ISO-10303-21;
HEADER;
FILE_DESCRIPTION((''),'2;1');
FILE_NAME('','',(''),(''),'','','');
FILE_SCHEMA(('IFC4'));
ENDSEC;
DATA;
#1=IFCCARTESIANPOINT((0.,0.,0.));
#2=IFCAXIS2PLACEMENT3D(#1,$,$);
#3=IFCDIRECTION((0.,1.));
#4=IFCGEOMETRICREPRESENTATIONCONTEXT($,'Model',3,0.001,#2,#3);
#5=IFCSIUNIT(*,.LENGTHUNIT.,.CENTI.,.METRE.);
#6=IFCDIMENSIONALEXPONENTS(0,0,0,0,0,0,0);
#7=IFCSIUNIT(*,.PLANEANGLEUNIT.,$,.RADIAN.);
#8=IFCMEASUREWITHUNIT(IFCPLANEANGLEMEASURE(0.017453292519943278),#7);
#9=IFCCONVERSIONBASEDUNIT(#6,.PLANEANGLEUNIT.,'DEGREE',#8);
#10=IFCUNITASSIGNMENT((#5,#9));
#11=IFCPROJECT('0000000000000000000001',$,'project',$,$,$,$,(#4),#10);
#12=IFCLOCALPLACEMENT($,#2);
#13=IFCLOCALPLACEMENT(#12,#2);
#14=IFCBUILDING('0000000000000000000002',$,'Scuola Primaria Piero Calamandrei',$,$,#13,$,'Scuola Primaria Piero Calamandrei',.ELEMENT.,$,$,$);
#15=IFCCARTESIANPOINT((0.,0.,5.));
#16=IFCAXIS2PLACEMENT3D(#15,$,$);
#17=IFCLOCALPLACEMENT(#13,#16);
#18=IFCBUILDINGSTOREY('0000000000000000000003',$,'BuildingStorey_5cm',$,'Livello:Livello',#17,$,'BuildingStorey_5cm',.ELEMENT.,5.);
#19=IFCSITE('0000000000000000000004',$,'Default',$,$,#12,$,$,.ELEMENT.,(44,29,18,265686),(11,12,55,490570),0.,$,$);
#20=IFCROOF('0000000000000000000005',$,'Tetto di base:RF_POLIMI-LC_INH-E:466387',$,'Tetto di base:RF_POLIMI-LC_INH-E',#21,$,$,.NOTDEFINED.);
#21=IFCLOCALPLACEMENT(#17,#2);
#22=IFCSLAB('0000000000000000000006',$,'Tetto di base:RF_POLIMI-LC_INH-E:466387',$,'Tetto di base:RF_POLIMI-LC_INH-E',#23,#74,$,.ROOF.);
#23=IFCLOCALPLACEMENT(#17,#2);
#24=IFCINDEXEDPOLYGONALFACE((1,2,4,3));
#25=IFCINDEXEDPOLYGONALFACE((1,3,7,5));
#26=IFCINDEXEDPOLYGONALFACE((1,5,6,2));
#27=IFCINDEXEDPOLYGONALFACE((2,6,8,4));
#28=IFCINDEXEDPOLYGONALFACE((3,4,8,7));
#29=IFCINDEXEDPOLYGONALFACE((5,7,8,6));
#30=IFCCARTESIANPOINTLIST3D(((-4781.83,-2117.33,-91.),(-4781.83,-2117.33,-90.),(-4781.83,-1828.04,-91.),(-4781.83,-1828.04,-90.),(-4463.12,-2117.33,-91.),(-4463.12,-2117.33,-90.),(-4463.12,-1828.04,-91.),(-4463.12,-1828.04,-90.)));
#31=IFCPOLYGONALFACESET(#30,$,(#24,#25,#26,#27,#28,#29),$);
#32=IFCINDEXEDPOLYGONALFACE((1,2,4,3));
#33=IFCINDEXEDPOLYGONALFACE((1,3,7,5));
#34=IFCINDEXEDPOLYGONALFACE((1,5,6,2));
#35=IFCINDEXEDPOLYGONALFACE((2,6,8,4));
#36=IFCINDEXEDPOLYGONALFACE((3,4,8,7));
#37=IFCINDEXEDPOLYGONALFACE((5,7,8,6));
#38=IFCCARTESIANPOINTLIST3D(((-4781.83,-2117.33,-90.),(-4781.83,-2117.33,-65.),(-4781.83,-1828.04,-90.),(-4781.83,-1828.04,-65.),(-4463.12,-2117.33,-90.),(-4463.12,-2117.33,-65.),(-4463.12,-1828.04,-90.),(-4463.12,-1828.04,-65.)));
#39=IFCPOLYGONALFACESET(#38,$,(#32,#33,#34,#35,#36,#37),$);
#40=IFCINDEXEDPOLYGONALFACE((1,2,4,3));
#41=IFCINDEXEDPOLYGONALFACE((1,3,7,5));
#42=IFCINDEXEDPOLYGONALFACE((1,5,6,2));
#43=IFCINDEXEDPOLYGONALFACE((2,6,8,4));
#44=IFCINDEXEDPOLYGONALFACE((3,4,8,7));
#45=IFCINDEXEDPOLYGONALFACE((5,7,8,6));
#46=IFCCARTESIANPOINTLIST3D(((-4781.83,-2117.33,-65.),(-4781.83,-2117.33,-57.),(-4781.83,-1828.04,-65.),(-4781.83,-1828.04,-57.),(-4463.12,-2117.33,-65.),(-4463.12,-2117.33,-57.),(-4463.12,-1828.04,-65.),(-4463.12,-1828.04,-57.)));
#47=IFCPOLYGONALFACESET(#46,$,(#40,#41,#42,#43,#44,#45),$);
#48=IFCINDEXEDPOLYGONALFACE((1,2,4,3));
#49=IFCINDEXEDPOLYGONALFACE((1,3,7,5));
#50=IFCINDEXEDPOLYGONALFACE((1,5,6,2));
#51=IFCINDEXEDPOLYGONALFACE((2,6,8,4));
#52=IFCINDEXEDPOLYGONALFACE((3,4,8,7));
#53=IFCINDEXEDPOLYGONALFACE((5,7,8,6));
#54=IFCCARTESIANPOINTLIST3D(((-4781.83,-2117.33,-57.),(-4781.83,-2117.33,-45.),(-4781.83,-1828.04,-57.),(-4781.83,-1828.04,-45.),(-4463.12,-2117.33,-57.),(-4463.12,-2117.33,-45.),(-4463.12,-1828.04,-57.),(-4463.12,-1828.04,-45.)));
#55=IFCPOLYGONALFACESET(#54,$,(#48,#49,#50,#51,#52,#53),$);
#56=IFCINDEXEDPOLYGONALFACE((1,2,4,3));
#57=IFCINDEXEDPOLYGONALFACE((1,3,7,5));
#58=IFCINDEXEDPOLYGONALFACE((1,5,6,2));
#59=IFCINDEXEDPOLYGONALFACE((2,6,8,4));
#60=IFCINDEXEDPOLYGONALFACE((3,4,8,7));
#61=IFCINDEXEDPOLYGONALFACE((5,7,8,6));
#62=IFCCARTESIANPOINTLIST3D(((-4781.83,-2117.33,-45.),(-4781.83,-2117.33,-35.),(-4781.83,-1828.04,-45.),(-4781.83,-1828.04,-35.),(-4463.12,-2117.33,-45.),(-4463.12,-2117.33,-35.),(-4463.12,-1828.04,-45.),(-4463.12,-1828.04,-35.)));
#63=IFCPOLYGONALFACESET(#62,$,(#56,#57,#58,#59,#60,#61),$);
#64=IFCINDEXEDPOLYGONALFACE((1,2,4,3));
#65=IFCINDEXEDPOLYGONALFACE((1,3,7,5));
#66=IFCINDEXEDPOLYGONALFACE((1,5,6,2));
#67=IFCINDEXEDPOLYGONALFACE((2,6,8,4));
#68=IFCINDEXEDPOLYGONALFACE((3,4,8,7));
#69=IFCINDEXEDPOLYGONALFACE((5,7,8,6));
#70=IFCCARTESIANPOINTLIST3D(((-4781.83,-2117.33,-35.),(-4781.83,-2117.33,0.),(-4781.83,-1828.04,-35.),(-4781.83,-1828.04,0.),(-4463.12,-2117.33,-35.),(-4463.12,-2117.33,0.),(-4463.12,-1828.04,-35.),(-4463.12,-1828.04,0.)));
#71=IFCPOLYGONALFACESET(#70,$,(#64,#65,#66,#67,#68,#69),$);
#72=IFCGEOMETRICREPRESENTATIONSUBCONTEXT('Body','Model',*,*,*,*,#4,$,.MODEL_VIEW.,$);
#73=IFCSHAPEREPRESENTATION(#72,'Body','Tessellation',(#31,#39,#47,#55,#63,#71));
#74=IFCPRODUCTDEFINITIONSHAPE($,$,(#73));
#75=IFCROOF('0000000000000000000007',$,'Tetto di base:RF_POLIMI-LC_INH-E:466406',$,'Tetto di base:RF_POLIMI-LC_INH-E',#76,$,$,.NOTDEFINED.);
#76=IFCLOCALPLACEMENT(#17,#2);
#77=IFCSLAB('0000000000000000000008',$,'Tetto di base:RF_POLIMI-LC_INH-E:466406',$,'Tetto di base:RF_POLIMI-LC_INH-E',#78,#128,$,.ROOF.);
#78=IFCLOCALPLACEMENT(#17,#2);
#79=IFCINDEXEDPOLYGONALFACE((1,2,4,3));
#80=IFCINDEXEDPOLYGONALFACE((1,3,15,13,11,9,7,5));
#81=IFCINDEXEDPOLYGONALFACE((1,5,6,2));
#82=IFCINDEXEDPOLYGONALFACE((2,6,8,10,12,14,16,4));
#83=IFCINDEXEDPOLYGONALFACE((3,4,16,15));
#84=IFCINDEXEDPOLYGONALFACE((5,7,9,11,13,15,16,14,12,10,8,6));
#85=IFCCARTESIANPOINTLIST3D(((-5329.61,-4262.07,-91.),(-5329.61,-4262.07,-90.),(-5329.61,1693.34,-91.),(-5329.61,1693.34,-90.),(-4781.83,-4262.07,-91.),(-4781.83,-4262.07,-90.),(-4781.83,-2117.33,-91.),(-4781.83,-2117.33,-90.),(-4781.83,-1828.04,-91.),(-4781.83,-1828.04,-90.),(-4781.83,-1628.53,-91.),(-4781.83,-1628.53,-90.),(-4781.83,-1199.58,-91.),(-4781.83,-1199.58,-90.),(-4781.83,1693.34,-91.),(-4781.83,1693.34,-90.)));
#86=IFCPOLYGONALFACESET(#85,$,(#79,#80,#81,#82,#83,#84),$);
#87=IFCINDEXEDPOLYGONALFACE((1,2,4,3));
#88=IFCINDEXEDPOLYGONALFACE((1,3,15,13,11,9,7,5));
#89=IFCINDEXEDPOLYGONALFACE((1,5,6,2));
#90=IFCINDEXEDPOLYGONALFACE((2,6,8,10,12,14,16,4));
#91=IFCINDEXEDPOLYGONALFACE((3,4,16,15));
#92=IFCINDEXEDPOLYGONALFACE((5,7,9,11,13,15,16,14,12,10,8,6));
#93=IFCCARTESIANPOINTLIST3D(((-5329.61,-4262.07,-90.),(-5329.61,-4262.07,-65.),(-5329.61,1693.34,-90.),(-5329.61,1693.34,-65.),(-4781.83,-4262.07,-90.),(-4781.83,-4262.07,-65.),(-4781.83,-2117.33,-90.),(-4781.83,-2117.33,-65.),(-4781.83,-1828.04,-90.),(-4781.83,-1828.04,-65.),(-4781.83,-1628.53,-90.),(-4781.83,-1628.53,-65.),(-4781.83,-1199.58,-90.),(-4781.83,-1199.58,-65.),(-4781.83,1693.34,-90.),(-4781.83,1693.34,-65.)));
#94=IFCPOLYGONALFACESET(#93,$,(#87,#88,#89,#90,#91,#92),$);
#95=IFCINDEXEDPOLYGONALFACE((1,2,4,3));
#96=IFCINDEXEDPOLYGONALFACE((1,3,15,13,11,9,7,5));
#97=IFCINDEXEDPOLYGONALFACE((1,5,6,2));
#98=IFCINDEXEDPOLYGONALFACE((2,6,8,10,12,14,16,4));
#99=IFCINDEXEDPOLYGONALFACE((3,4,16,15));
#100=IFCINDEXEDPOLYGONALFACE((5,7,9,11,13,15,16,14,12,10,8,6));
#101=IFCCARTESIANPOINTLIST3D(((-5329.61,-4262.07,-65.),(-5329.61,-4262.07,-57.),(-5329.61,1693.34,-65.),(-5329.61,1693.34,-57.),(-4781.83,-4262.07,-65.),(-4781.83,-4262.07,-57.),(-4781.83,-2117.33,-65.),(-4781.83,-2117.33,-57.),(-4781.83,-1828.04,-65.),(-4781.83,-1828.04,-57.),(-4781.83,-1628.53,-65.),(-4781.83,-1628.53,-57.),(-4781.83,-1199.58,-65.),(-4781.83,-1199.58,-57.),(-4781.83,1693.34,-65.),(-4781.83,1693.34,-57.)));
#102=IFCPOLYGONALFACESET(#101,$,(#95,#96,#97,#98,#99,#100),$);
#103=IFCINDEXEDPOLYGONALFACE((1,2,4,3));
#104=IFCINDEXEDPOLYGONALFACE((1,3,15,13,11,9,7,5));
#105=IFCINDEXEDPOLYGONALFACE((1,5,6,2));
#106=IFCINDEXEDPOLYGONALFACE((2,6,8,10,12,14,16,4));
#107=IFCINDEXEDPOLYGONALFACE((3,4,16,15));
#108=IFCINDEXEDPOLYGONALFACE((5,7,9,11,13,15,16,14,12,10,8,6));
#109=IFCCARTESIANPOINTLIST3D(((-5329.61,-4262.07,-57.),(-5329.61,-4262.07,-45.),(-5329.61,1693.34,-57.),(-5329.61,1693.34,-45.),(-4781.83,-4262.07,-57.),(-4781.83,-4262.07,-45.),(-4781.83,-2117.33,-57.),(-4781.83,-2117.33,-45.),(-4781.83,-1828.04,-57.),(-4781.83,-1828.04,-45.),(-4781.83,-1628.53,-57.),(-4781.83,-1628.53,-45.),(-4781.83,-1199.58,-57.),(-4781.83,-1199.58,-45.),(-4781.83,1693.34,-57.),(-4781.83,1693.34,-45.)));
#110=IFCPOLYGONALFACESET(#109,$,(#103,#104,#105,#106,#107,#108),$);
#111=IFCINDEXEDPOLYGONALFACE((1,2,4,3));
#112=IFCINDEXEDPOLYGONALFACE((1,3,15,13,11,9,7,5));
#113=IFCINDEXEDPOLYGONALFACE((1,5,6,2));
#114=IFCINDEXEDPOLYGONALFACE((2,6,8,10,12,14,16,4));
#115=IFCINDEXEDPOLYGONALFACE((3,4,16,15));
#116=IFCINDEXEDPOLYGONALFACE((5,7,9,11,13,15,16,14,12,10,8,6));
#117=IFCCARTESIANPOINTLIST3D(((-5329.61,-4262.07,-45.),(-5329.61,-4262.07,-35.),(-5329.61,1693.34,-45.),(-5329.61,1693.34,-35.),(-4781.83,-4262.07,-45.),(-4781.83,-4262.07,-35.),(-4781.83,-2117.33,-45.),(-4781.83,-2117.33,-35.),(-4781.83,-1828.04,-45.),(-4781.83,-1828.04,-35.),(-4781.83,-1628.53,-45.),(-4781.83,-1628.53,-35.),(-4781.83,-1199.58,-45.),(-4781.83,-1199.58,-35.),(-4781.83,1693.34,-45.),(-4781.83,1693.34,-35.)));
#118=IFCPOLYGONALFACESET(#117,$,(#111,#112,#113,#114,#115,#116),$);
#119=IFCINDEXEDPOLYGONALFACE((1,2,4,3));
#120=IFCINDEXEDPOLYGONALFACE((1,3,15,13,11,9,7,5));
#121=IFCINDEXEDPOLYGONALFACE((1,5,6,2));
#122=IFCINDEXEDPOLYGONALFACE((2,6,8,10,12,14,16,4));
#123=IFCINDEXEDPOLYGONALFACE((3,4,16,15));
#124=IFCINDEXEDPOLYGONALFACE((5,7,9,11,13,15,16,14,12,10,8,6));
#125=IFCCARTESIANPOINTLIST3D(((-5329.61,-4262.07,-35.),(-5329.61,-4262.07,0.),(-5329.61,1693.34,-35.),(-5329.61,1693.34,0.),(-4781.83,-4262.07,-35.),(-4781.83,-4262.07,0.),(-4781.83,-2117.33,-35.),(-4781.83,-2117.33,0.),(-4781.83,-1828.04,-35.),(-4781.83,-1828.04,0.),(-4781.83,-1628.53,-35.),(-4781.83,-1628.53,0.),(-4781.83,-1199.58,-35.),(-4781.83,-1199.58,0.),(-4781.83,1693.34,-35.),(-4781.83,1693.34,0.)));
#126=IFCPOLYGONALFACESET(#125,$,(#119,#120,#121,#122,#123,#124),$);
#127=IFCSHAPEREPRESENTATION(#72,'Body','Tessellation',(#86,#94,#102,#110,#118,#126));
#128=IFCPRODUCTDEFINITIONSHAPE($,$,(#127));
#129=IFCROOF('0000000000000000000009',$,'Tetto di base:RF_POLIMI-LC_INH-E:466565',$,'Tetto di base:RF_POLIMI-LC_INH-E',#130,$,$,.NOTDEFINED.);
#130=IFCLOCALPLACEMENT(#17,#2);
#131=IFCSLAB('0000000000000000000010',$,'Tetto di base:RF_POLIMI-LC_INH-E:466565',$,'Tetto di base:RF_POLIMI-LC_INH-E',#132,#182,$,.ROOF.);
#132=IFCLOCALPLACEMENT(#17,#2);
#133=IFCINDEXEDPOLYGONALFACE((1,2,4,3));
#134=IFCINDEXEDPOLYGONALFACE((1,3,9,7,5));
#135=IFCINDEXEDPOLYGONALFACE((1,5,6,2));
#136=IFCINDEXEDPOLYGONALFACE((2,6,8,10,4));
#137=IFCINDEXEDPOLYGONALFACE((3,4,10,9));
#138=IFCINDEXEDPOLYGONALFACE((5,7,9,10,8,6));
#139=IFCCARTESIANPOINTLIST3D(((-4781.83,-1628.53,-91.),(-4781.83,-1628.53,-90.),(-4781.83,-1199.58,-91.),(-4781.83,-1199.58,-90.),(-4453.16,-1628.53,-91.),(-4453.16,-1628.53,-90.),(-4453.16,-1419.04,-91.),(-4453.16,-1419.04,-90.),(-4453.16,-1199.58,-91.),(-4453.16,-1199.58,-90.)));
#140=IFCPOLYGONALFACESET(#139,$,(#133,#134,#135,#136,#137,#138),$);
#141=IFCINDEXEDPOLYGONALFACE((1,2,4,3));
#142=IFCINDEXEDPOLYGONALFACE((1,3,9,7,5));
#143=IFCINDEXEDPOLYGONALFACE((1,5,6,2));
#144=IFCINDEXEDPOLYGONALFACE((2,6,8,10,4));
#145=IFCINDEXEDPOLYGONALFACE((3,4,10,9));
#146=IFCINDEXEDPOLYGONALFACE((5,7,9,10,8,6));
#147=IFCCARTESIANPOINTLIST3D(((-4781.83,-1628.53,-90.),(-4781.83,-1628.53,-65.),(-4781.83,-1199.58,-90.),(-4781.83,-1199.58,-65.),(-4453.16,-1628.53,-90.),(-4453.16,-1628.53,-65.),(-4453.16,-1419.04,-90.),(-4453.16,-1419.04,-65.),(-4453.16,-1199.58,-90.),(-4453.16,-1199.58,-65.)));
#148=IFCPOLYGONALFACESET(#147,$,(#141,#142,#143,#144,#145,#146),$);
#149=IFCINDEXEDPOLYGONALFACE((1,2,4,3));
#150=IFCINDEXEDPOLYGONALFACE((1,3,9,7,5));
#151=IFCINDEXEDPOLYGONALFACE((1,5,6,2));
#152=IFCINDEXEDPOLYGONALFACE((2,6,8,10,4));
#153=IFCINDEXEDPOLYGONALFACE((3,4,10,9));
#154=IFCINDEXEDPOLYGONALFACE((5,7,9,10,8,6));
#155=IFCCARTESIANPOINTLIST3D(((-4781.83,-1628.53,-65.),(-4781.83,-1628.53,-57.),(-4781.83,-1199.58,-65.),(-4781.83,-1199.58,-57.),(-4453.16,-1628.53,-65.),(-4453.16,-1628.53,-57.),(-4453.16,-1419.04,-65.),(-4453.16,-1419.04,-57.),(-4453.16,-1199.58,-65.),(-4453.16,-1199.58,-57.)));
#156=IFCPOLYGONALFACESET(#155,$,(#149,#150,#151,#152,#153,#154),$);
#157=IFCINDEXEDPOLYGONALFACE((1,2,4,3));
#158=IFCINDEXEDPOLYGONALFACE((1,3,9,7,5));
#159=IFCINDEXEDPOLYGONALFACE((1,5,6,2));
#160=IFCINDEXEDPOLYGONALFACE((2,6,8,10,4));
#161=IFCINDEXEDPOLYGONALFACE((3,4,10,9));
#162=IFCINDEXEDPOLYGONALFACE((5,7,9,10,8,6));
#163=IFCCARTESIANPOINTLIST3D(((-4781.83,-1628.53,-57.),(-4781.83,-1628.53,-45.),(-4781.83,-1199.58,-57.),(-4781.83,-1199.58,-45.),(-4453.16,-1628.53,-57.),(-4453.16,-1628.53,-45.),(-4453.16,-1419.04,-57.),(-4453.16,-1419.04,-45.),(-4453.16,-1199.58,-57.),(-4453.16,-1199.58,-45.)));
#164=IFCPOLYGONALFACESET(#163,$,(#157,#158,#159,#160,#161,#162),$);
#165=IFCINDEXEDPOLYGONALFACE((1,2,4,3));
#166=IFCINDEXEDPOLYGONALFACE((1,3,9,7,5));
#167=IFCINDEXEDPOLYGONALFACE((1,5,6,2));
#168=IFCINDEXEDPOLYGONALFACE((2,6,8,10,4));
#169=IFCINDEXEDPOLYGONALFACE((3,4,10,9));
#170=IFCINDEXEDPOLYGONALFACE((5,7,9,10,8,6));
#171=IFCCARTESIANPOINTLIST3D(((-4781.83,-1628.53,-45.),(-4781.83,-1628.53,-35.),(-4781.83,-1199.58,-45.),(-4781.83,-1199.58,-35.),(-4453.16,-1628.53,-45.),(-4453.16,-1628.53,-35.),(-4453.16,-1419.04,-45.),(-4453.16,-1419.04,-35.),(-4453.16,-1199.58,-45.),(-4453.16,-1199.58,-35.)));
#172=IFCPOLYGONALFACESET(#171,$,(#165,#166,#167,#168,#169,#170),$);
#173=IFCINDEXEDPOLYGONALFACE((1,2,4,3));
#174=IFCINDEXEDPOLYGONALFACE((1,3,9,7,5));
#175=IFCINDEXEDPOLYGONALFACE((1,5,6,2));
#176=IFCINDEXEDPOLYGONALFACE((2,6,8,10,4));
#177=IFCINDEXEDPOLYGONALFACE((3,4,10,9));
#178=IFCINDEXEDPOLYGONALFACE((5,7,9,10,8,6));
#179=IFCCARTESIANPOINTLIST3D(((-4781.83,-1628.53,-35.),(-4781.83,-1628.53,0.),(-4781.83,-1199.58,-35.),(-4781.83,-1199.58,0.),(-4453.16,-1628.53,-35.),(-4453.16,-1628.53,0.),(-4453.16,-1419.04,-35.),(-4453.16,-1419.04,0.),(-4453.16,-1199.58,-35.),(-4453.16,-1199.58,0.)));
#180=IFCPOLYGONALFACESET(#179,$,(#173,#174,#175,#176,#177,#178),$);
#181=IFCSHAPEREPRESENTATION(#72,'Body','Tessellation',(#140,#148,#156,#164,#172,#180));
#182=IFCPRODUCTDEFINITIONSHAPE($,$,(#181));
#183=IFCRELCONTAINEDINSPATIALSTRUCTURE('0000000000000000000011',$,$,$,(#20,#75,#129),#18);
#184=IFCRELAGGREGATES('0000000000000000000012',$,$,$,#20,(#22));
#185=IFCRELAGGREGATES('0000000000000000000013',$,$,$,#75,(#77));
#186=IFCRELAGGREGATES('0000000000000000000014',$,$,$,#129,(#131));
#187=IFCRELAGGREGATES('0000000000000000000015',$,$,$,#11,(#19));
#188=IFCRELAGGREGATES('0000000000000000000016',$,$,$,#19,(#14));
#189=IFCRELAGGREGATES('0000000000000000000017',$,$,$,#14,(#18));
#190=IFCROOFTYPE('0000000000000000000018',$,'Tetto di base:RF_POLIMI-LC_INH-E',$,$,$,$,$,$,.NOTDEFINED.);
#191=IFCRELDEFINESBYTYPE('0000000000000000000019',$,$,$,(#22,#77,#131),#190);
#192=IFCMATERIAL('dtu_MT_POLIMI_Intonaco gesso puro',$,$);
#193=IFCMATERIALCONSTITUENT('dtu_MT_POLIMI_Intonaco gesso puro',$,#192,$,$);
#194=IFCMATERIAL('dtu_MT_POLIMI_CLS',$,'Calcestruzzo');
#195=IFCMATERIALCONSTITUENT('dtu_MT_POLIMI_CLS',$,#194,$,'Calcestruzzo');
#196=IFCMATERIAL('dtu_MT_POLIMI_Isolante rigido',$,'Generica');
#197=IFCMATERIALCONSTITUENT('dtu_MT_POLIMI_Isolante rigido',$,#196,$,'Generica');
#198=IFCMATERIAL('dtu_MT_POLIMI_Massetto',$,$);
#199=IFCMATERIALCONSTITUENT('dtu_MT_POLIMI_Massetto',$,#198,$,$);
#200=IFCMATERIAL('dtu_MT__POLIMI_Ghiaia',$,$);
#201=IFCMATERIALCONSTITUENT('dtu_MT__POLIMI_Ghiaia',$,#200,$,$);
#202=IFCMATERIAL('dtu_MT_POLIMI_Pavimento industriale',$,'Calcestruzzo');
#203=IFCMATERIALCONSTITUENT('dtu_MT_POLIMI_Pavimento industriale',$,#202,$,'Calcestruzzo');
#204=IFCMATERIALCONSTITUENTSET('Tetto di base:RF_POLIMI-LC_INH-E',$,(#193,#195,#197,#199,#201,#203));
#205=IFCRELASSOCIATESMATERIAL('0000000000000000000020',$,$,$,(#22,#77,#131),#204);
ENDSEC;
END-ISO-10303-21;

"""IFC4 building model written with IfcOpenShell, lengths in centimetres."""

from ifc_helpers import new_model, entity, si_unit, converted_unit, direction, frame, origin, place, context, subcontext, project, spatial, indexed_curve, outline, extrude, material, constituent, constituent_set, type_object, element, aggregate, save


model = new_model("IFC4")

# Units and contexts
model_context = context("Model", 3, precision=0.001, world=origin(), true_north=direction((0.0, 1.0)))
body_context = subcontext(model_context, "Body", "Model", "MODEL_VIEW")
ifc_project = project(units=[si_unit("LENGTHUNIT", "METRE", prefix="CENTI"), converted_unit("PLANEANGLEUNIT", "DEGREE", entity("IfcPlaneAngleMeasure", 0.017453292519943278), si_unit("PLANEANGLEUNIT", "RADIAN"), dimensions=[0, 0, 0, 0, 0, 0, 0])], contexts=[model_context])

# Site, building, storey
site_placement = place(None, origin())
site = spatial("IfcSite", under=ifc_project, at=site_placement, Name="Default", CompositionType="ELEMENT", RefLatitude=(44, 29, 18, 265686), RefLongitude=(11, 12, 55, 490570), RefElevation=0.0)
building_placement = place(site_placement, origin())
building = spatial("IfcBuilding", under=site, at=building_placement, Name="Scuola Primaria Piero Calamandrei", LongName="Scuola Primaria Piero Calamandrei", CompositionType="ELEMENT")
storey_placement = place(building_placement, frame((0.0, 0.0, 5.0)))
storey = spatial("IfcBuildingStorey", under=building, at=storey_placement, Name="BuildingStorey_5cm", ObjectType="Livello:Livello", LongName="BuildingStorey_5cm", CompositionType="ELEMENT", Elevation=5.0)

# Roofs, slabs
ifc_material_1 = material(Name="dtu_MT_POLIMI_Intonaco gesso puro")
ifc_constituent_1 = constituent(ifc_material_1, Name="dtu_MT_POLIMI_Intonaco gesso puro")
ifc_material_2 = material(Name="dtu_MT_POLIMI_CLS", Category="Calcestruzzo")
ifc_constituent_2 = constituent(ifc_material_2, Name="dtu_MT_POLIMI_CLS", Category="Calcestruzzo")
ifc_material_3 = material(Name="dtu_MT_POLIMI_Isolante rigido", Category="Generica")
ifc_constituent_3 = constituent(ifc_material_3, Name="dtu_MT_POLIMI_Isolante rigido", Category="Generica")
ifc_material_4 = material(Name="dtu_MT_POLIMI_Massetto")
ifc_constituent_4 = constituent(ifc_material_4, Name="dtu_MT_POLIMI_Massetto")
ifc_material_5 = material(Name="dtu_MT__POLIMI_Ghiaia")
ifc_constituent_5 = constituent(ifc_material_5, Name="dtu_MT__POLIMI_Ghiaia")
ifc_material_6 = material(Name="dtu_MT_POLIMI_Pavimento industriale", Category="Calcestruzzo")
ifc_constituent_6 = constituent(ifc_material_6, Name="dtu_MT_POLIMI_Pavimento industriale", Category="Calcestruzzo")
ifc_constituent_set_1 = constituent_set(constituents=[ifc_constituent_1, ifc_constituent_2, ifc_constituent_3, ifc_constituent_4, ifc_constituent_5, ifc_constituent_6], Name="Tetto di base:RF_POLIMI-LC_INH-E")
roof_type = type_object("IfcRoofType", Name="Tetto di base:RF_POLIMI-LC_INH-E", PredefinedType="NOTDEFINED")
roof_1_placement = place(storey_placement, frame((-4781.83, -2117.33, -91.0)))
roof_1 = element("IfcRoof", 1, at=roof_1_placement, inside=storey, Name="Tetto di base:RF_POLIMI-LC_INH-E:466387", ObjectType="Tetto di base:RF_POLIMI-LC_INH-E", PredefinedType="NOTDEFINED")
slab_1_placement = place(roof_1_placement, origin())
slab_1 = element("IfcSlab", 2, at=slab_1_placement, type_object=roof_type, material=ifc_constituent_set_1, Name="Tetto di base:RF_POLIMI-LC_INH-E:466387", ObjectType="Tetto di base:RF_POLIMI-LC_INH-E", PredefinedType="ROOF", context=body_context, shape_type="SweptSolid", body=[
    extrude(outline(indexed_curve([(159.35, 144.65), (-159.35, 144.65), (-159.35, -144.65), (159.35, -144.65), (159.35, 144.65)], self_intersect=False)), frame((159.35, 144.65, 0.0)), (0.0, 0.0, 1.0), 1.0),
    extrude(outline(indexed_curve([(159.35, 144.65), (-159.35, 144.65), (-159.35, -144.65), (159.35, -144.65), (159.35, 144.65)], self_intersect=False)), frame((159.35, 144.65, 1.0)), (0.0, 0.0, 1.0), 25.0),
    extrude(outline(indexed_curve([(159.35, 144.65), (-159.35, 144.65), (-159.35, -144.65), (159.35, -144.65), (159.35, 144.65)], self_intersect=False)), frame((159.35, 144.65, 26.0)), (0.0, 0.0, 1.0), 8.0),
    extrude(outline(indexed_curve([(159.35, 144.65), (-159.35, 144.65), (-159.35, -144.65), (159.35, -144.65), (159.35, 144.65)], self_intersect=False)), frame((159.35, 144.65, 34.0)), (0.0, 0.0, 1.0), 12.0),
    extrude(outline(indexed_curve([(159.35, 144.65), (-159.35, 144.65), (-159.35, -144.65), (159.35, -144.65), (159.35, 144.65)], self_intersect=False)), frame((159.35, 144.65, 46.0)), (0.0, 0.0, 1.0), 10.0),
    extrude(outline(indexed_curve([(159.35, 144.65), (-159.35, 144.65), (-159.35, -144.65), (159.35, -144.65), (159.35, 144.65)], self_intersect=False)), frame((159.35, 144.65, 56.0)), (0.0, 0.0, 1.0), 35.0),
])
aggregate(roof_1, [slab_1])
roof_2_placement = place(storey_placement, frame((-5329.61, -4262.07, -91.0)))
roof_2 = element("IfcRoof", 3, at=roof_2_placement, inside=storey, Name="Tetto di base:RF_POLIMI-LC_INH-E:466406", ObjectType="Tetto di base:RF_POLIMI-LC_INH-E", PredefinedType="NOTDEFINED")
slab_2_placement = place(roof_2_placement, origin())
slab_2 = element("IfcSlab", 4, at=slab_2_placement, type_object=roof_type, material=ifc_constituent_set_1, Name="Tetto di base:RF_POLIMI-LC_INH-E:466406", ObjectType="Tetto di base:RF_POLIMI-LC_INH-E", PredefinedType="ROOF", context=body_context, shape_type="SweptSolid", body=[
    extrude(outline(indexed_curve([(273.89, -543.67), (273.89, -344.16), (273.89, 84.79), (273.89, 2977.7), (-273.89, 2977.7), (-273.89, -2977.7), (273.89, -2977.7), (273.89, -832.96), (273.89, -543.67)], self_intersect=False)), frame((273.89, 2977.7, 0.0)), (0.0, 0.0, 1.0), 1.0),
    extrude(outline(indexed_curve([(273.89, -543.67), (273.89, -344.16), (273.89, 84.79), (273.89, 2977.7), (-273.89, 2977.7), (-273.89, -2977.7), (273.89, -2977.7), (273.89, -832.96), (273.89, -543.67)], self_intersect=False)), frame((273.89, 2977.7, 1.0)), (0.0, 0.0, 1.0), 25.0),
    extrude(outline(indexed_curve([(273.89, -543.67), (273.89, -344.16), (273.89, 84.79), (273.89, 2977.7), (-273.89, 2977.7), (-273.89, -2977.7), (273.89, -2977.7), (273.89, -832.96), (273.89, -543.67)], self_intersect=False)), frame((273.89, 2977.7, 26.0)), (0.0, 0.0, 1.0), 8.0),
    extrude(outline(indexed_curve([(273.89, -543.67), (273.89, -344.16), (273.89, 84.79), (273.89, 2977.7), (-273.89, 2977.7), (-273.89, -2977.7), (273.89, -2977.7), (273.89, -832.96), (273.89, -543.67)], self_intersect=False)), frame((273.89, 2977.7, 34.0)), (0.0, 0.0, 1.0), 12.0),
    extrude(outline(indexed_curve([(273.89, -543.67), (273.89, -344.16), (273.89, 84.79), (273.89, 2977.7), (-273.89, 2977.7), (-273.89, -2977.7), (273.89, -2977.7), (273.89, -832.96), (273.89, -543.67)], self_intersect=False)), frame((273.89, 2977.7, 46.0)), (0.0, 0.0, 1.0), 10.0),
    extrude(outline(indexed_curve([(273.89, -543.67), (273.89, -344.16), (273.89, 84.79), (273.89, 2977.7), (-273.89, 2977.7), (-273.89, -2977.7), (273.89, -2977.7), (273.89, -832.96), (273.89, -543.67)], self_intersect=False)), frame((273.89, 2977.7, 56.0)), (0.0, 0.0, 1.0), 35.0),
])
aggregate(roof_2, [slab_2])
roof_3_placement = place(storey_placement, frame((-4781.83, -1628.53, -91.0)))
roof_3 = element("IfcRoof", 5, at=roof_3_placement, inside=storey, Name="Tetto di base:RF_POLIMI-LC_INH-E:466565", ObjectType="Tetto di base:RF_POLIMI-LC_INH-E", PredefinedType="NOTDEFINED")
slab_3_placement = place(roof_3_placement, origin())
slab_3 = element("IfcSlab", 6, at=slab_3_placement, type_object=roof_type, material=ifc_constituent_set_1, Name="Tetto di base:RF_POLIMI-LC_INH-E:466565", ObjectType="Tetto di base:RF_POLIMI-LC_INH-E", PredefinedType="ROOF", context=body_context, shape_type="SweptSolid", body=[
    extrude(outline(indexed_curve([(164.33, -4.99), (164.33, 214.47), (-164.33, 214.47), (-164.33, -214.47), (164.33, -214.47), (164.33, -4.99)], self_intersect=False)), frame((164.33, 214.47, 0.0)), (0.0, 0.0, 1.0), 1.0),
    extrude(outline(indexed_curve([(164.33, -4.99), (164.33, 214.47), (-164.33, 214.47), (-164.33, -214.47), (164.33, -214.47), (164.33, -4.99)], self_intersect=False)), frame((164.33, 214.47, 1.0)), (0.0, 0.0, 1.0), 25.0),
    extrude(outline(indexed_curve([(164.33, -4.99), (164.33, 214.47), (-164.33, 214.47), (-164.33, -214.47), (164.33, -214.47), (164.33, -4.99)], self_intersect=False)), frame((164.33, 214.47, 26.0)), (0.0, 0.0, 1.0), 8.0),
    extrude(outline(indexed_curve([(164.33, -4.99), (164.33, 214.47), (-164.33, 214.47), (-164.33, -214.47), (164.33, -214.47), (164.33, -4.99)], self_intersect=False)), frame((164.33, 214.47, 34.0)), (0.0, 0.0, 1.0), 12.0),
    extrude(outline(indexed_curve([(164.33, -4.99), (164.33, 214.47), (-164.33, 214.47), (-164.33, -214.47), (164.33, -214.47), (164.33, -4.99)], self_intersect=False)), frame((164.33, 214.47, 46.0)), (0.0, 0.0, 1.0), 10.0),
    extrude(outline(indexed_curve([(164.33, -4.99), (164.33, 214.47), (-164.33, 214.47), (-164.33, -214.47), (164.33, -214.47), (164.33, -4.99)], self_intersect=False)), frame((164.33, 214.47, 56.0)), (0.0, 0.0, 1.0), 35.0),
])
aggregate(roof_3, [slab_3])

save(model, "model.ifc")
